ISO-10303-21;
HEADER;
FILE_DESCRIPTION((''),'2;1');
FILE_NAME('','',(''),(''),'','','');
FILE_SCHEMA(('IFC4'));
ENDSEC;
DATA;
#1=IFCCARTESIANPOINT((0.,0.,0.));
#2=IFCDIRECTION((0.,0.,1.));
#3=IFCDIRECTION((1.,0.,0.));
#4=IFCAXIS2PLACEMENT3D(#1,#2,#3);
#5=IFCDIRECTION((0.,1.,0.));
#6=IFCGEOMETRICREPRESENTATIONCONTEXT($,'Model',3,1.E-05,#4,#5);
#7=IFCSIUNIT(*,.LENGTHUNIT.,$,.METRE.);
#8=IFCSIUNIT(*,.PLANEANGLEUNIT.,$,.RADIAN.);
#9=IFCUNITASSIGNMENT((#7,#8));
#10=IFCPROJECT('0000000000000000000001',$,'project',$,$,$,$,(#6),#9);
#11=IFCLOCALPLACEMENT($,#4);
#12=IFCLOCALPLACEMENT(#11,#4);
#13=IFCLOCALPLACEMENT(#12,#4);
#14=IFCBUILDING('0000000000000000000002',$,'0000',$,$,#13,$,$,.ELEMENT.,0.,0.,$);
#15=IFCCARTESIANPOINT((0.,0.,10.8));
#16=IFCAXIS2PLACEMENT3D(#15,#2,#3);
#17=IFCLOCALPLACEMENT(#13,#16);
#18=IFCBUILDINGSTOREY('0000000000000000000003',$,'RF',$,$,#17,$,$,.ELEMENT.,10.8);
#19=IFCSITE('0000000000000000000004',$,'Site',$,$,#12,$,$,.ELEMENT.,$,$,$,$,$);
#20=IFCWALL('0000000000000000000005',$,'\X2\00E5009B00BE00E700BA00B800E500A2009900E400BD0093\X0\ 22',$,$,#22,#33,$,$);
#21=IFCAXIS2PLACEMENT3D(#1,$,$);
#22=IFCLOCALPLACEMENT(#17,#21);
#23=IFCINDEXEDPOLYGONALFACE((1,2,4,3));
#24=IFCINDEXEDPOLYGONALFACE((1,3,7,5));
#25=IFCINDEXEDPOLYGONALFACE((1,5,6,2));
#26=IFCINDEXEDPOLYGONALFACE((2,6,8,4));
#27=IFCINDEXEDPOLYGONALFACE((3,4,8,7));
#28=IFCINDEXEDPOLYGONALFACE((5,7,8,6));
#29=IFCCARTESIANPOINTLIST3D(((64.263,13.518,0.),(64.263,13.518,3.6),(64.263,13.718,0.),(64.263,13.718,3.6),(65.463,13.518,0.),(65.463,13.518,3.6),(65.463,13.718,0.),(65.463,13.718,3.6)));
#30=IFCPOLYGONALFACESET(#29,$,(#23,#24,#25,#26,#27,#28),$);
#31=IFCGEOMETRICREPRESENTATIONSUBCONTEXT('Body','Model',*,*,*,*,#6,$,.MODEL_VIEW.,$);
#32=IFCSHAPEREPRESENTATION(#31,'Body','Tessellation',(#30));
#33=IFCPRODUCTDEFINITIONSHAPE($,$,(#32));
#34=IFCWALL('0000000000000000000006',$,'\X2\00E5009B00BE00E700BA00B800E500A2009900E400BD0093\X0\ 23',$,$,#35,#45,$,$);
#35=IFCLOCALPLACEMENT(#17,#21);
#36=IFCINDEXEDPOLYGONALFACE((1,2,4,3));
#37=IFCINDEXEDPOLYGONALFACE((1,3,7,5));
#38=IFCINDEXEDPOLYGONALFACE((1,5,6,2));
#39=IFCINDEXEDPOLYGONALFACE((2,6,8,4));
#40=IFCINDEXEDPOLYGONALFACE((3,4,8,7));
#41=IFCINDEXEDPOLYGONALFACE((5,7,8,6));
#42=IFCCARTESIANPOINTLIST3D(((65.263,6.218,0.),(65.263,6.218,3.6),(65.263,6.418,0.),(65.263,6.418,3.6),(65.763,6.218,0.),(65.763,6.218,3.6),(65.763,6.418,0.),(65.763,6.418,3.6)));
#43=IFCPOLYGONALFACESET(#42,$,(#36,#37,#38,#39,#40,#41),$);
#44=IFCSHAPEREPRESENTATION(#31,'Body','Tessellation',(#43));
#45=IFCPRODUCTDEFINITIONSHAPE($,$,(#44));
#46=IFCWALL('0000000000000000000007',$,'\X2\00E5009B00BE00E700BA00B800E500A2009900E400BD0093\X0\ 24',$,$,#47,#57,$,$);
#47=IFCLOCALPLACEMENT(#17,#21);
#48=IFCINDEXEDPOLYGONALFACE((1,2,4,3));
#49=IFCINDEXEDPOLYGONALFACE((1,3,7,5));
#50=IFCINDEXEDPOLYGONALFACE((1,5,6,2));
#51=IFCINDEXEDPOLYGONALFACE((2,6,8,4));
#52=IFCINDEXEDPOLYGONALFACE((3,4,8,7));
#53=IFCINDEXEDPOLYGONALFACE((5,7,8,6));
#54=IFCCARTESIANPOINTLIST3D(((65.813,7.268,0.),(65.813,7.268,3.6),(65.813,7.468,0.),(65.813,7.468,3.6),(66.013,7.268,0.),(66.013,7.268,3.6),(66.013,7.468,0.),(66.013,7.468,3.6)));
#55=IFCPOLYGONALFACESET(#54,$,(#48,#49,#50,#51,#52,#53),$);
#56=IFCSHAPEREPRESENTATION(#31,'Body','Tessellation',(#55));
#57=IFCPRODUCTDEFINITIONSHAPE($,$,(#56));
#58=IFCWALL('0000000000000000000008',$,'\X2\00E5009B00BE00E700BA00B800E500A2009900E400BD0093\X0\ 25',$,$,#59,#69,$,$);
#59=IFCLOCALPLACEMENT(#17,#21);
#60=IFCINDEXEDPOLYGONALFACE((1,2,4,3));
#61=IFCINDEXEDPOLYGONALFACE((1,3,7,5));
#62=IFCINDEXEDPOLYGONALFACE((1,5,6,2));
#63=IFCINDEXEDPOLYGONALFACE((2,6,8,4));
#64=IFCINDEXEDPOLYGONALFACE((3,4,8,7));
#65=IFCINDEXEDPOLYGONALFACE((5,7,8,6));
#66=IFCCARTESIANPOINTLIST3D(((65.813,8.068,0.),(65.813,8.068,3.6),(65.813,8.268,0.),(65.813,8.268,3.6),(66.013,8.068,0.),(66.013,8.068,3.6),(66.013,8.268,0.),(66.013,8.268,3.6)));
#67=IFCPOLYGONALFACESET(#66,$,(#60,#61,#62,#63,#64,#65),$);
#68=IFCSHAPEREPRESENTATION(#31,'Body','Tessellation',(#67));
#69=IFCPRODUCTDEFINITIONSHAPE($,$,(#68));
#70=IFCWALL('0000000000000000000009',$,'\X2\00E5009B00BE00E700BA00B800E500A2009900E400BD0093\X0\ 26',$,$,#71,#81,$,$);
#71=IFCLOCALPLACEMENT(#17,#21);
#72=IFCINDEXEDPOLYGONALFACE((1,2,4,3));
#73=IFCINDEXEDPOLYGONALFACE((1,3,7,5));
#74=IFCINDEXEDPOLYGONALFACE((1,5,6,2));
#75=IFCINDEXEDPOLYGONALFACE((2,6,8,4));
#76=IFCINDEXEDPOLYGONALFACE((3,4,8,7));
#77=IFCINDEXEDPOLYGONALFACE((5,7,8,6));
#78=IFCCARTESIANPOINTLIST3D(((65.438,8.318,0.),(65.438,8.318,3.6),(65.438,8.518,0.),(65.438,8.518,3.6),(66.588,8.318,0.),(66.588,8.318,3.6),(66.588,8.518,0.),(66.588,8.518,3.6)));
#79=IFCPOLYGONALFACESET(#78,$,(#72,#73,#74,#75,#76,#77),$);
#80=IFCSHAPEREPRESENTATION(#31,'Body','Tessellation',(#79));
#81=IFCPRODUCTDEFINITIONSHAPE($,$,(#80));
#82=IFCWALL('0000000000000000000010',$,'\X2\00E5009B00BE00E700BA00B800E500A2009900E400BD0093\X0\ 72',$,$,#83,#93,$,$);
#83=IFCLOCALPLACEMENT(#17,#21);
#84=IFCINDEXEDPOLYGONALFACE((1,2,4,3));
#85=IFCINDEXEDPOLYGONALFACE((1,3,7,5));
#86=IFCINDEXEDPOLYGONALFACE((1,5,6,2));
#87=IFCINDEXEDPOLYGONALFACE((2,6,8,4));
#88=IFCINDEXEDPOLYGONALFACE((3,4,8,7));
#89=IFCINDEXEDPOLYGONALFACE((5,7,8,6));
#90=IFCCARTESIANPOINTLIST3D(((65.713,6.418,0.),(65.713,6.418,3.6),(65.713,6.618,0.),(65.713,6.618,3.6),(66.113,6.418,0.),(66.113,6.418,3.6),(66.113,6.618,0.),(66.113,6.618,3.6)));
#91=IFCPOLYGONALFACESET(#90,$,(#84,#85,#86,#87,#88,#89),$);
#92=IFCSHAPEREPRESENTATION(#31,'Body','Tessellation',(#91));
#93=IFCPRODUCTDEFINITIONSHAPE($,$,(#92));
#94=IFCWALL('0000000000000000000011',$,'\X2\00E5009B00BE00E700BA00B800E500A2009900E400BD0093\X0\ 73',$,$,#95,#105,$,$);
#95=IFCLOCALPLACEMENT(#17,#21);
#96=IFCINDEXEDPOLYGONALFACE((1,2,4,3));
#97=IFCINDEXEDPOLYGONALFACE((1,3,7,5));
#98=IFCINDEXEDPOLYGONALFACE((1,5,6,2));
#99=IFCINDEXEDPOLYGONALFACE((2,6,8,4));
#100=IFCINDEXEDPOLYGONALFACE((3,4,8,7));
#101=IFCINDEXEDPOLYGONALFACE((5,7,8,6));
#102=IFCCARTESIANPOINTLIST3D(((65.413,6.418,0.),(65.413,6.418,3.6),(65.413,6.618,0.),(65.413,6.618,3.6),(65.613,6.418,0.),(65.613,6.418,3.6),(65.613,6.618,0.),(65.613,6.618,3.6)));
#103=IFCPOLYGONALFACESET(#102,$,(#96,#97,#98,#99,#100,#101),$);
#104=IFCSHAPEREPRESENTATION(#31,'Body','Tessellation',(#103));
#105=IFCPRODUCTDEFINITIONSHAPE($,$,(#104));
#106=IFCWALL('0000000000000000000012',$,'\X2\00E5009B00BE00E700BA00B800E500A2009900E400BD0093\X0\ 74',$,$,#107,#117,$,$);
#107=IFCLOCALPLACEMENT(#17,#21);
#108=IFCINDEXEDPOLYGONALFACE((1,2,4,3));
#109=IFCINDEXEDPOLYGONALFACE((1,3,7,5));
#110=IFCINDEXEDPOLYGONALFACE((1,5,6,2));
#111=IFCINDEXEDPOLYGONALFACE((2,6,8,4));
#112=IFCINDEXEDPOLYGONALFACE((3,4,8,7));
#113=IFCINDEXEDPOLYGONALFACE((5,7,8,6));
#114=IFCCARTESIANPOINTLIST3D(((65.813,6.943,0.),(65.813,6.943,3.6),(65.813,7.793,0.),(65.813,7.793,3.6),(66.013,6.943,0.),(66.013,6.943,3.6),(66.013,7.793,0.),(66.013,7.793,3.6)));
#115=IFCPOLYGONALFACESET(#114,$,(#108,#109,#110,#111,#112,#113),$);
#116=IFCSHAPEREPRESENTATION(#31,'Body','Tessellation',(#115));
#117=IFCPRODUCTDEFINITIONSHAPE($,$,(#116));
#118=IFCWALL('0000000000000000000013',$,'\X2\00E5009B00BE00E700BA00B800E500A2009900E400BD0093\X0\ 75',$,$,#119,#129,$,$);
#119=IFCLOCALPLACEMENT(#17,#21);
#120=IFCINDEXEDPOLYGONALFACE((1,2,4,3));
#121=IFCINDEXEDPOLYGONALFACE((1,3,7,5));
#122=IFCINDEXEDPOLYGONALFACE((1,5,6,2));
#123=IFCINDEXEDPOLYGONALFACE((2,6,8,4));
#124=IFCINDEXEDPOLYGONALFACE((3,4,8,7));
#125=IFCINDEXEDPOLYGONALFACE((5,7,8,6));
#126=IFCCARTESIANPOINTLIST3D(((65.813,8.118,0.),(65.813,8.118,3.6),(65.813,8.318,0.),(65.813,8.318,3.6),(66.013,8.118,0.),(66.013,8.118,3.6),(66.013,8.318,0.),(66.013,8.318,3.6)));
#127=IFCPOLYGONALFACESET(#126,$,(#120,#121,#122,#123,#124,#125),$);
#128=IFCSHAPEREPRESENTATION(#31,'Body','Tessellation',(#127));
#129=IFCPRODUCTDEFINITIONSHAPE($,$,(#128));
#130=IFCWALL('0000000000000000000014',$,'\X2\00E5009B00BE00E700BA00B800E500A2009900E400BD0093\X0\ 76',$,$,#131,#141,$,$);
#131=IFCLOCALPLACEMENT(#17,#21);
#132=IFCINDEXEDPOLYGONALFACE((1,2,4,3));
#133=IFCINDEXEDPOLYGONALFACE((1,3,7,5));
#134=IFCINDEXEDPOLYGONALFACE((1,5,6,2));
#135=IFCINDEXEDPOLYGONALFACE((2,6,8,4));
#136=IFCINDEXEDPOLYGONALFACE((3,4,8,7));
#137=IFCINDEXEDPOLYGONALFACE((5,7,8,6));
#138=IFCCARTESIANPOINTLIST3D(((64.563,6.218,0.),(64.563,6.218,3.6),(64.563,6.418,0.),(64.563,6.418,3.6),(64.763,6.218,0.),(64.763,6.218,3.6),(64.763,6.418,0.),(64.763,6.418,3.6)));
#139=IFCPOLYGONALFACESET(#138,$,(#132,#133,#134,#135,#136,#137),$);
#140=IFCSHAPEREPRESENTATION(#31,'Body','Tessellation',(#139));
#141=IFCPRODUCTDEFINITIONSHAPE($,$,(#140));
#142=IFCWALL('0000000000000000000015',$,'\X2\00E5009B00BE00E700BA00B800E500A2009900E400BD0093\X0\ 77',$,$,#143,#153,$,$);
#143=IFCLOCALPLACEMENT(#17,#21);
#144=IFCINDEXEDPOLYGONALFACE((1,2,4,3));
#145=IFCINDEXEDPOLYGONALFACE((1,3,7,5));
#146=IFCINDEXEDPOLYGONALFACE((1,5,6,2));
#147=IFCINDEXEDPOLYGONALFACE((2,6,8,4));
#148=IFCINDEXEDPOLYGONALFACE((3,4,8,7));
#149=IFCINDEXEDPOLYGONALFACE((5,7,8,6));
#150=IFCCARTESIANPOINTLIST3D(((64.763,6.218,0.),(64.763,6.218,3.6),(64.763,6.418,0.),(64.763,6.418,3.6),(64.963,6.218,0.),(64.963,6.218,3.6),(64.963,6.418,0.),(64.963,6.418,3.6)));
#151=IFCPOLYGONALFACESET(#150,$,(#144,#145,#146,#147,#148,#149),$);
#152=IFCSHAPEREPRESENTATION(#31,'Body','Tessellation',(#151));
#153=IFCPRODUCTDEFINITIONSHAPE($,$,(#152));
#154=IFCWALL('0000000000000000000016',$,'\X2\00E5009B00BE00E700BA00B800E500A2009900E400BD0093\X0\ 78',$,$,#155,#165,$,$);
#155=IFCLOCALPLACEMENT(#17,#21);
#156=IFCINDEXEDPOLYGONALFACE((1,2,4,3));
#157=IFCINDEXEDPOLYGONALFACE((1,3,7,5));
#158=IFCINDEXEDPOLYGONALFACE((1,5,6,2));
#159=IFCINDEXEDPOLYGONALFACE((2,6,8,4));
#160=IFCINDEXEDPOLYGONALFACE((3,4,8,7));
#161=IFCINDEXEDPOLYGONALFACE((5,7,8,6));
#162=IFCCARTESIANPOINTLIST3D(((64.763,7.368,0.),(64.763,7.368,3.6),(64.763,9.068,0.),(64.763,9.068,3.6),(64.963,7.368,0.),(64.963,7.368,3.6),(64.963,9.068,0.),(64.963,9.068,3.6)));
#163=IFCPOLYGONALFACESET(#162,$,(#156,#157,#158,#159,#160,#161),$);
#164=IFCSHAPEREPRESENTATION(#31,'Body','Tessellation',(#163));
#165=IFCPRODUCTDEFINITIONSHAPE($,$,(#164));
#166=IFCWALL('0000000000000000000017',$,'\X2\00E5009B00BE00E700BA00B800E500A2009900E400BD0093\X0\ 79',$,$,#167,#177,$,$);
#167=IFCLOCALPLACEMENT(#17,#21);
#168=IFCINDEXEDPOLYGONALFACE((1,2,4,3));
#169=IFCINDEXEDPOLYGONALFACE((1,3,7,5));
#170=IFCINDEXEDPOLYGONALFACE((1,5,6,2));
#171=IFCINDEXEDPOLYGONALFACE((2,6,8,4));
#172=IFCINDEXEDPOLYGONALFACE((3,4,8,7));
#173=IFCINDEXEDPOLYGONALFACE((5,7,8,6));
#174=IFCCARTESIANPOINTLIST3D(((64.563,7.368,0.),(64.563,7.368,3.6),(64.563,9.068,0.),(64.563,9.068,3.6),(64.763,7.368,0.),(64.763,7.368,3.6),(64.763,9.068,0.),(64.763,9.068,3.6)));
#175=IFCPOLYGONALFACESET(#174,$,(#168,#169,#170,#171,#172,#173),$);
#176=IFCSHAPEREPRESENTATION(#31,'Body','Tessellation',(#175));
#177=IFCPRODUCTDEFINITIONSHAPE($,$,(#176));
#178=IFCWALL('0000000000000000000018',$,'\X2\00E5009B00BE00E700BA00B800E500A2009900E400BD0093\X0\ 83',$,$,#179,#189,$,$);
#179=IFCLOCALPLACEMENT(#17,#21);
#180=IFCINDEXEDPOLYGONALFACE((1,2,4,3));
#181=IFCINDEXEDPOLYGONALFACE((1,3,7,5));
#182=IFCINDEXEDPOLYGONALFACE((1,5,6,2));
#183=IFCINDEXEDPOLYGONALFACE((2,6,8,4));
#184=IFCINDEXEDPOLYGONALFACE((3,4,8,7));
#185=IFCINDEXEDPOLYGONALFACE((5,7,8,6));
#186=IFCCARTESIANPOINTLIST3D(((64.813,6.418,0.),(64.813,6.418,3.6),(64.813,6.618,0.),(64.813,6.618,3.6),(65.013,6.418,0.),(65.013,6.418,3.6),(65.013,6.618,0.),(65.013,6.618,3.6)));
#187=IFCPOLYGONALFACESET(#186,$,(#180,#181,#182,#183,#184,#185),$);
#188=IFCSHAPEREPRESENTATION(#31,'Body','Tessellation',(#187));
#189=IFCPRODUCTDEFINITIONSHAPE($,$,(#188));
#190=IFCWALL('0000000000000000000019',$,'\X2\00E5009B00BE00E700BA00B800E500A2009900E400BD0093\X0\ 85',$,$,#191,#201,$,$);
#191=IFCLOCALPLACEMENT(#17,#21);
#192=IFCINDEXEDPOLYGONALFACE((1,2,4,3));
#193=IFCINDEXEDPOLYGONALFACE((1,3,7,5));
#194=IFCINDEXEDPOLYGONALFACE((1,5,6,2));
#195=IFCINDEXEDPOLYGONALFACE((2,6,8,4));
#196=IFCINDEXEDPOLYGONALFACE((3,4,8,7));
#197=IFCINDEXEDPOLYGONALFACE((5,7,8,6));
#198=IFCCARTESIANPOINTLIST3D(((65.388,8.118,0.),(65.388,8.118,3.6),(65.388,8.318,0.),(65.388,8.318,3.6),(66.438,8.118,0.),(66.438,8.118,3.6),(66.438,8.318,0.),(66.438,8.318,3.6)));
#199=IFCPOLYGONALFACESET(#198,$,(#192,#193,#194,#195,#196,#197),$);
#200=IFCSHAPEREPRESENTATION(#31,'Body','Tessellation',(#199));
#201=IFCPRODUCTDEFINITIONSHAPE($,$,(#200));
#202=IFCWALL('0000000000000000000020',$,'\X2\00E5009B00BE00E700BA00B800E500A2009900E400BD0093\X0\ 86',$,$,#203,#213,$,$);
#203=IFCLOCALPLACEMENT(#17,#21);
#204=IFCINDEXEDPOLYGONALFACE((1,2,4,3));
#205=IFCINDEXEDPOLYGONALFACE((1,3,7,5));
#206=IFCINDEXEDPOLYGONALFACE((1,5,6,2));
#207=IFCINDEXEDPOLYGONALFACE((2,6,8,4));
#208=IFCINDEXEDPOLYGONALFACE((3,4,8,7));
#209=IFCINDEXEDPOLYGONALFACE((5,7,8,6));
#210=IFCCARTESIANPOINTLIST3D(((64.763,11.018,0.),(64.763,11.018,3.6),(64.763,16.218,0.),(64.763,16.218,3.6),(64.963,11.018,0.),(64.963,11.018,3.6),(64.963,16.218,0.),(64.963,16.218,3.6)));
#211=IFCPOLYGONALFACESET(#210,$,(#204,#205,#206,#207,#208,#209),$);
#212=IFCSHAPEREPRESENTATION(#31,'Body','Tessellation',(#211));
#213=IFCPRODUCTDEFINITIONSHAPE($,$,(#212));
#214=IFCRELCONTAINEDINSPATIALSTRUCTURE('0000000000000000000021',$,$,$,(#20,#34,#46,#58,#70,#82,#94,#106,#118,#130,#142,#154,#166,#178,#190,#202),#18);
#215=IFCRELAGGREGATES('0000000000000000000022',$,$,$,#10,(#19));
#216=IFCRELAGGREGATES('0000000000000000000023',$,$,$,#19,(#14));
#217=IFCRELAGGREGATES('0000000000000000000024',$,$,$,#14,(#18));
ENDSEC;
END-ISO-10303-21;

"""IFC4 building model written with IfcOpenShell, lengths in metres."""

from ifc_helpers import new_model, si_unit, direction, frame, frame_2d, origin_with_axes, place, context, subcontext, project, spatial, rectangle, extrude, element, save


model = new_model("IFC4")

# Units and contexts
model_context = context("Model", 3, precision=1e-05, world=origin_with_axes(), true_north=direction((0.0, 1.0, 0.0)))
body_context = subcontext(model_context, "Body", "Model", "MODEL_VIEW")
ifc_project = project(units=[si_unit("LENGTHUNIT", "METRE"), si_unit("PLANEANGLEUNIT", "RADIAN")], contexts=[model_context])

# Site, building, storey
placement = place(None, origin_with_axes())
site_placement = place(placement, origin_with_axes())
site = spatial("IfcSite", under=ifc_project, at=site_placement, Name="Site", CompositionType="ELEMENT")
building_placement = place(site_placement, origin_with_axes())
building = spatial("IfcBuilding", under=site, at=building_placement, Name="0000", CompositionType="ELEMENT", ElevationOfRefHeight=0.0, ElevationOfTerrain=0.0)
storey_placement = place(building_placement, frame((0.0, 0.0, 10.8), z_axis=(0.0, 0.0, 1.0), x_axis=(1.0, 0.0, 0.0)))
storey = spatial("IfcBuildingStorey", under=building, at=storey_placement, Name="RF", CompositionType="ELEMENT", Elevation=10.8)

# Walls
wall_1_placement = place(storey_placement, frame((64.863, 13.618, 0.0), z_axis=(0.0, 0.0, 1.0), x_axis=(1.0, 0.0, 0.0)))
element("IfcWall", 1, at=wall_1_placement, inside=storey, Name="å\u009b¾çº¸å¢\u0099ä½\u0093 22", context=body_context, shape_type="SweptSolid", body=[
    extrude(rectangle(XDim=1.2, YDim=0.2, at=frame_2d((0.0, 0.0), x_axis=(1.0, 0.0, 0.0))), frame((0.0, 0.0, 0.0), z_axis=(0.0, 0.0, 1.0)), (0.0, 0.0, 1.0), 3.6),
])
wall_2_placement = place(storey_placement, frame((65.513, 6.318, 0.0), z_axis=(0.0, 0.0, 1.0), x_axis=(1.0, 0.0, 0.0)))
element("IfcWall", 2, at=wall_2_placement, inside=storey, Name="å\u009b¾çº¸å¢\u0099ä½\u0093 23", context=body_context, shape_type="SweptSolid", body=[
    extrude(rectangle(XDim=0.5, YDim=0.2, at=frame_2d((0.0, 0.0), x_axis=(1.0, 0.0, 0.0))), frame((0.0, 0.0, 0.0), z_axis=(0.0, 0.0, 1.0)), (0.0, 0.0, 1.0), 3.6),
])
for number, where, z_axis, x_axis, name in (
    (3, (65.913, 7.368, 0.0), (0.0, 0.0, 1.0), (1.0, 0.0, 0.0), "å\u009b¾çº¸å¢\u0099ä½\u0093 24"),
    (4, (65.913, 8.168, 0.0), (0.0, 0.0, 1.0), (1.0, 0.0, 0.0), "å\u009b¾çº¸å¢\u0099ä½\u0093 25"),
):
    element("IfcWall", number, at=place(storey_placement, frame(where, z_axis=z_axis, x_axis=x_axis)), inside=storey, Name=name, context=body_context, shape_type="SweptSolid", body=[
        extrude(rectangle(XDim=0.2, YDim=0.2, at=frame_2d((0.0, 0.0), x_axis=(1.0, 0.0, 0.0))), frame((0.0, 0.0, 0.0), z_axis=(0.0, 0.0, 1.0)), (0.0, 0.0, 1.0), 3.6),
    ])
wall_3_placement = place(storey_placement, frame((66.013, 8.418, 0.0), z_axis=(0.0, 0.0, 1.0), x_axis=(-1.0, 0.0, 0.0)))
element("IfcWall", 5, at=wall_3_placement, inside=storey, Name="å\u009b¾çº¸å¢\u0099ä½\u0093 26", context=body_context, shape_type="SweptSolid", body=[
    extrude(rectangle(XDim=1.15, YDim=0.2, at=frame_2d((0.0, 0.0), x_axis=(1.0, 0.0, 0.0))), frame((0.0, 0.0, 0.0), z_axis=(0.0, 0.0, 1.0)), (0.0, 0.0, 1.0), 3.6),
])
wall_4_placement = place(storey_placement, frame((65.913, 6.518, 0.0), z_axis=(0.0, 0.0, 1.0), x_axis=(-1.0, 0.0, 0.0)))
element("IfcWall", 6, at=wall_4_placement, inside=storey, Name="å\u009b¾çº¸å¢\u0099ä½\u0093 72", context=body_context, shape_type="SweptSolid", body=[
    extrude(rectangle(XDim=0.4, YDim=0.2, at=frame_2d((0.0, 0.0), x_axis=(1.0, 0.0, 0.0))), frame((0.0, 0.0, 0.0), z_axis=(0.0, 0.0, 1.0)), (0.0, 0.0, 1.0), 3.6),
])
wall_5_placement = place(storey_placement, frame((65.513, 6.518, 0.0), z_axis=(0.0, 0.0, 1.0), x_axis=(0.0, -1.0, 0.0)))
element("IfcWall", 7, at=wall_5_placement, inside=storey, Name="å\u009b¾çº¸å¢\u0099ä½\u0093 73", context=body_context, shape_type="SweptSolid", body=[
    extrude(rectangle(XDim=0.2, YDim=0.2, at=frame_2d((0.0, 0.0), x_axis=(1.0, 0.0, 0.0))), frame((0.0, 0.0, 0.0), z_axis=(0.0, 0.0, 1.0)), (0.0, 0.0, 1.0), 3.6),
])
wall_6_placement = place(storey_placement, frame((65.913, 7.368, 0.0), z_axis=(0.0, 0.0, 1.0), x_axis=(0.0, -1.0, 0.0)))
element("IfcWall", 8, at=wall_6_placement, inside=storey, Name="å\u009b¾çº¸å¢\u0099ä½\u0093 74", context=body_context, shape_type="SweptSolid", body=[
    extrude(rectangle(XDim=0.85, YDim=0.2, at=frame_2d((0.0, 0.0), x_axis=(1.0, 0.0, 0.0))), frame((0.0, 0.0, 0.0), z_axis=(0.0, 0.0, 1.0)), (0.0, 0.0, 1.0), 3.6),
])
for number, where, z_axis, x_axis, name in (
    (9, (65.913, 8.218, 0.0), (0.0, 0.0, 1.0), (0.0, -1.0, 0.0), "å\u009b¾çº¸å¢\u0099ä½\u0093 75"),
    (10, (64.663, 6.318, 0.0), (0.0, 0.0, 1.0), (1.0, 0.0, 0.0), "å\u009b¾çº¸å¢\u0099ä½\u0093 76"),
    (11, (64.863, 6.318, 0.0), (0.0, 0.0, 1.0), (1.0, 0.0, 0.0), "å\u009b¾çº¸å¢\u0099ä½\u0093 77"),
):
    element("IfcWall", number, at=place(storey_placement, frame(where, z_axis=z_axis, x_axis=x_axis)), inside=storey, Name=name, context=body_context, shape_type="SweptSolid", body=[
        extrude(rectangle(XDim=0.2, YDim=0.2, at=frame_2d((0.0, 0.0), x_axis=(1.0, 0.0, 0.0))), frame((0.0, 0.0, 0.0), z_axis=(0.0, 0.0, 1.0)), (0.0, 0.0, 1.0), 3.6),
    ])
for number, where, z_axis, x_axis, name in (
    (12, (64.863, 8.218, 0.0), (0.0, 0.0, 1.0), (0.0, -1.0, 0.0), "å\u009b¾çº¸å¢\u0099ä½\u0093 78"),
    (13, (64.663, 8.218, 0.0), (0.0, 0.0, 1.0), (0.0, -1.0, 0.0), "å\u009b¾çº¸å¢\u0099ä½\u0093 79"),
):
    element("IfcWall", number, at=place(storey_placement, frame(where, z_axis=z_axis, x_axis=x_axis)), inside=storey, Name=name, context=body_context, shape_type="SweptSolid", body=[
        extrude(rectangle(XDim=1.7, YDim=0.2, at=frame_2d((0.0, 0.0), x_axis=(1.0, 0.0, 0.0))), frame((0.0, 0.0, 0.0), z_axis=(0.0, 0.0, 1.0)), (0.0, 0.0, 1.0), 3.6),
    ])
for number, where, z_axis, x_axis, name in (
    (14, (64.913, 6.518, 0.0), (0.0, 0.0, 1.0), (-1.0, 0.0, 0.0), "å\u009b¾çº¸å¢\u0099ä½\u0093 83"),
):
    element("IfcWall", number, at=place(storey_placement, frame(where, z_axis=z_axis, x_axis=x_axis)), inside=storey, Name=name, context=body_context, shape_type="SweptSolid", body=[
        extrude(rectangle(XDim=0.2, YDim=0.2, at=frame_2d((0.0, 0.0), x_axis=(1.0, 0.0, 0.0))), frame((0.0, 0.0, 0.0), z_axis=(0.0, 0.0, 1.0)), (0.0, 0.0, 1.0), 3.6),
    ])
wall_7_placement = place(storey_placement, frame((65.913, 8.218, 0.0), z_axis=(0.0, 0.0, 1.0), x_axis=(-1.0, 0.0, 0.0)))
element("IfcWall", 15, at=wall_7_placement, inside=storey, Name="å\u009b¾çº¸å¢\u0099ä½\u0093 85", context=body_context, shape_type="SweptSolid", body=[
    extrude(rectangle(XDim=1.05, YDim=0.2, at=frame_2d((0.0, 0.0), x_axis=(1.0, 0.0, 0.0))), frame((0.0, 0.0, 0.0), z_axis=(0.0, 0.0, 1.0)), (0.0, 0.0, 1.0), 3.6),
])
for number, where, z_axis, x_axis, name in (
    (16, (64.863, 13.618, 0.0), (0.0, 0.0, 1.0), (0.0, -1.0, 0.0), "å\u009b¾çº¸å¢\u0099ä½\u0093 86"),
):
    element("IfcWall", number, at=place(storey_placement, frame(where, z_axis=z_axis, x_axis=x_axis)), inside=storey, Name=name, context=body_context, shape_type="SweptSolid", body=[
        extrude(rectangle(XDim=5.2, YDim=0.2, at=frame_2d((0.0, 0.0), x_axis=(1.0, 0.0, 0.0))), frame((0.0, 0.0, 0.0), z_axis=(0.0, 0.0, 1.0)), (0.0, 0.0, 1.0), 3.6),
    ])

save(model, "model.ifc")
